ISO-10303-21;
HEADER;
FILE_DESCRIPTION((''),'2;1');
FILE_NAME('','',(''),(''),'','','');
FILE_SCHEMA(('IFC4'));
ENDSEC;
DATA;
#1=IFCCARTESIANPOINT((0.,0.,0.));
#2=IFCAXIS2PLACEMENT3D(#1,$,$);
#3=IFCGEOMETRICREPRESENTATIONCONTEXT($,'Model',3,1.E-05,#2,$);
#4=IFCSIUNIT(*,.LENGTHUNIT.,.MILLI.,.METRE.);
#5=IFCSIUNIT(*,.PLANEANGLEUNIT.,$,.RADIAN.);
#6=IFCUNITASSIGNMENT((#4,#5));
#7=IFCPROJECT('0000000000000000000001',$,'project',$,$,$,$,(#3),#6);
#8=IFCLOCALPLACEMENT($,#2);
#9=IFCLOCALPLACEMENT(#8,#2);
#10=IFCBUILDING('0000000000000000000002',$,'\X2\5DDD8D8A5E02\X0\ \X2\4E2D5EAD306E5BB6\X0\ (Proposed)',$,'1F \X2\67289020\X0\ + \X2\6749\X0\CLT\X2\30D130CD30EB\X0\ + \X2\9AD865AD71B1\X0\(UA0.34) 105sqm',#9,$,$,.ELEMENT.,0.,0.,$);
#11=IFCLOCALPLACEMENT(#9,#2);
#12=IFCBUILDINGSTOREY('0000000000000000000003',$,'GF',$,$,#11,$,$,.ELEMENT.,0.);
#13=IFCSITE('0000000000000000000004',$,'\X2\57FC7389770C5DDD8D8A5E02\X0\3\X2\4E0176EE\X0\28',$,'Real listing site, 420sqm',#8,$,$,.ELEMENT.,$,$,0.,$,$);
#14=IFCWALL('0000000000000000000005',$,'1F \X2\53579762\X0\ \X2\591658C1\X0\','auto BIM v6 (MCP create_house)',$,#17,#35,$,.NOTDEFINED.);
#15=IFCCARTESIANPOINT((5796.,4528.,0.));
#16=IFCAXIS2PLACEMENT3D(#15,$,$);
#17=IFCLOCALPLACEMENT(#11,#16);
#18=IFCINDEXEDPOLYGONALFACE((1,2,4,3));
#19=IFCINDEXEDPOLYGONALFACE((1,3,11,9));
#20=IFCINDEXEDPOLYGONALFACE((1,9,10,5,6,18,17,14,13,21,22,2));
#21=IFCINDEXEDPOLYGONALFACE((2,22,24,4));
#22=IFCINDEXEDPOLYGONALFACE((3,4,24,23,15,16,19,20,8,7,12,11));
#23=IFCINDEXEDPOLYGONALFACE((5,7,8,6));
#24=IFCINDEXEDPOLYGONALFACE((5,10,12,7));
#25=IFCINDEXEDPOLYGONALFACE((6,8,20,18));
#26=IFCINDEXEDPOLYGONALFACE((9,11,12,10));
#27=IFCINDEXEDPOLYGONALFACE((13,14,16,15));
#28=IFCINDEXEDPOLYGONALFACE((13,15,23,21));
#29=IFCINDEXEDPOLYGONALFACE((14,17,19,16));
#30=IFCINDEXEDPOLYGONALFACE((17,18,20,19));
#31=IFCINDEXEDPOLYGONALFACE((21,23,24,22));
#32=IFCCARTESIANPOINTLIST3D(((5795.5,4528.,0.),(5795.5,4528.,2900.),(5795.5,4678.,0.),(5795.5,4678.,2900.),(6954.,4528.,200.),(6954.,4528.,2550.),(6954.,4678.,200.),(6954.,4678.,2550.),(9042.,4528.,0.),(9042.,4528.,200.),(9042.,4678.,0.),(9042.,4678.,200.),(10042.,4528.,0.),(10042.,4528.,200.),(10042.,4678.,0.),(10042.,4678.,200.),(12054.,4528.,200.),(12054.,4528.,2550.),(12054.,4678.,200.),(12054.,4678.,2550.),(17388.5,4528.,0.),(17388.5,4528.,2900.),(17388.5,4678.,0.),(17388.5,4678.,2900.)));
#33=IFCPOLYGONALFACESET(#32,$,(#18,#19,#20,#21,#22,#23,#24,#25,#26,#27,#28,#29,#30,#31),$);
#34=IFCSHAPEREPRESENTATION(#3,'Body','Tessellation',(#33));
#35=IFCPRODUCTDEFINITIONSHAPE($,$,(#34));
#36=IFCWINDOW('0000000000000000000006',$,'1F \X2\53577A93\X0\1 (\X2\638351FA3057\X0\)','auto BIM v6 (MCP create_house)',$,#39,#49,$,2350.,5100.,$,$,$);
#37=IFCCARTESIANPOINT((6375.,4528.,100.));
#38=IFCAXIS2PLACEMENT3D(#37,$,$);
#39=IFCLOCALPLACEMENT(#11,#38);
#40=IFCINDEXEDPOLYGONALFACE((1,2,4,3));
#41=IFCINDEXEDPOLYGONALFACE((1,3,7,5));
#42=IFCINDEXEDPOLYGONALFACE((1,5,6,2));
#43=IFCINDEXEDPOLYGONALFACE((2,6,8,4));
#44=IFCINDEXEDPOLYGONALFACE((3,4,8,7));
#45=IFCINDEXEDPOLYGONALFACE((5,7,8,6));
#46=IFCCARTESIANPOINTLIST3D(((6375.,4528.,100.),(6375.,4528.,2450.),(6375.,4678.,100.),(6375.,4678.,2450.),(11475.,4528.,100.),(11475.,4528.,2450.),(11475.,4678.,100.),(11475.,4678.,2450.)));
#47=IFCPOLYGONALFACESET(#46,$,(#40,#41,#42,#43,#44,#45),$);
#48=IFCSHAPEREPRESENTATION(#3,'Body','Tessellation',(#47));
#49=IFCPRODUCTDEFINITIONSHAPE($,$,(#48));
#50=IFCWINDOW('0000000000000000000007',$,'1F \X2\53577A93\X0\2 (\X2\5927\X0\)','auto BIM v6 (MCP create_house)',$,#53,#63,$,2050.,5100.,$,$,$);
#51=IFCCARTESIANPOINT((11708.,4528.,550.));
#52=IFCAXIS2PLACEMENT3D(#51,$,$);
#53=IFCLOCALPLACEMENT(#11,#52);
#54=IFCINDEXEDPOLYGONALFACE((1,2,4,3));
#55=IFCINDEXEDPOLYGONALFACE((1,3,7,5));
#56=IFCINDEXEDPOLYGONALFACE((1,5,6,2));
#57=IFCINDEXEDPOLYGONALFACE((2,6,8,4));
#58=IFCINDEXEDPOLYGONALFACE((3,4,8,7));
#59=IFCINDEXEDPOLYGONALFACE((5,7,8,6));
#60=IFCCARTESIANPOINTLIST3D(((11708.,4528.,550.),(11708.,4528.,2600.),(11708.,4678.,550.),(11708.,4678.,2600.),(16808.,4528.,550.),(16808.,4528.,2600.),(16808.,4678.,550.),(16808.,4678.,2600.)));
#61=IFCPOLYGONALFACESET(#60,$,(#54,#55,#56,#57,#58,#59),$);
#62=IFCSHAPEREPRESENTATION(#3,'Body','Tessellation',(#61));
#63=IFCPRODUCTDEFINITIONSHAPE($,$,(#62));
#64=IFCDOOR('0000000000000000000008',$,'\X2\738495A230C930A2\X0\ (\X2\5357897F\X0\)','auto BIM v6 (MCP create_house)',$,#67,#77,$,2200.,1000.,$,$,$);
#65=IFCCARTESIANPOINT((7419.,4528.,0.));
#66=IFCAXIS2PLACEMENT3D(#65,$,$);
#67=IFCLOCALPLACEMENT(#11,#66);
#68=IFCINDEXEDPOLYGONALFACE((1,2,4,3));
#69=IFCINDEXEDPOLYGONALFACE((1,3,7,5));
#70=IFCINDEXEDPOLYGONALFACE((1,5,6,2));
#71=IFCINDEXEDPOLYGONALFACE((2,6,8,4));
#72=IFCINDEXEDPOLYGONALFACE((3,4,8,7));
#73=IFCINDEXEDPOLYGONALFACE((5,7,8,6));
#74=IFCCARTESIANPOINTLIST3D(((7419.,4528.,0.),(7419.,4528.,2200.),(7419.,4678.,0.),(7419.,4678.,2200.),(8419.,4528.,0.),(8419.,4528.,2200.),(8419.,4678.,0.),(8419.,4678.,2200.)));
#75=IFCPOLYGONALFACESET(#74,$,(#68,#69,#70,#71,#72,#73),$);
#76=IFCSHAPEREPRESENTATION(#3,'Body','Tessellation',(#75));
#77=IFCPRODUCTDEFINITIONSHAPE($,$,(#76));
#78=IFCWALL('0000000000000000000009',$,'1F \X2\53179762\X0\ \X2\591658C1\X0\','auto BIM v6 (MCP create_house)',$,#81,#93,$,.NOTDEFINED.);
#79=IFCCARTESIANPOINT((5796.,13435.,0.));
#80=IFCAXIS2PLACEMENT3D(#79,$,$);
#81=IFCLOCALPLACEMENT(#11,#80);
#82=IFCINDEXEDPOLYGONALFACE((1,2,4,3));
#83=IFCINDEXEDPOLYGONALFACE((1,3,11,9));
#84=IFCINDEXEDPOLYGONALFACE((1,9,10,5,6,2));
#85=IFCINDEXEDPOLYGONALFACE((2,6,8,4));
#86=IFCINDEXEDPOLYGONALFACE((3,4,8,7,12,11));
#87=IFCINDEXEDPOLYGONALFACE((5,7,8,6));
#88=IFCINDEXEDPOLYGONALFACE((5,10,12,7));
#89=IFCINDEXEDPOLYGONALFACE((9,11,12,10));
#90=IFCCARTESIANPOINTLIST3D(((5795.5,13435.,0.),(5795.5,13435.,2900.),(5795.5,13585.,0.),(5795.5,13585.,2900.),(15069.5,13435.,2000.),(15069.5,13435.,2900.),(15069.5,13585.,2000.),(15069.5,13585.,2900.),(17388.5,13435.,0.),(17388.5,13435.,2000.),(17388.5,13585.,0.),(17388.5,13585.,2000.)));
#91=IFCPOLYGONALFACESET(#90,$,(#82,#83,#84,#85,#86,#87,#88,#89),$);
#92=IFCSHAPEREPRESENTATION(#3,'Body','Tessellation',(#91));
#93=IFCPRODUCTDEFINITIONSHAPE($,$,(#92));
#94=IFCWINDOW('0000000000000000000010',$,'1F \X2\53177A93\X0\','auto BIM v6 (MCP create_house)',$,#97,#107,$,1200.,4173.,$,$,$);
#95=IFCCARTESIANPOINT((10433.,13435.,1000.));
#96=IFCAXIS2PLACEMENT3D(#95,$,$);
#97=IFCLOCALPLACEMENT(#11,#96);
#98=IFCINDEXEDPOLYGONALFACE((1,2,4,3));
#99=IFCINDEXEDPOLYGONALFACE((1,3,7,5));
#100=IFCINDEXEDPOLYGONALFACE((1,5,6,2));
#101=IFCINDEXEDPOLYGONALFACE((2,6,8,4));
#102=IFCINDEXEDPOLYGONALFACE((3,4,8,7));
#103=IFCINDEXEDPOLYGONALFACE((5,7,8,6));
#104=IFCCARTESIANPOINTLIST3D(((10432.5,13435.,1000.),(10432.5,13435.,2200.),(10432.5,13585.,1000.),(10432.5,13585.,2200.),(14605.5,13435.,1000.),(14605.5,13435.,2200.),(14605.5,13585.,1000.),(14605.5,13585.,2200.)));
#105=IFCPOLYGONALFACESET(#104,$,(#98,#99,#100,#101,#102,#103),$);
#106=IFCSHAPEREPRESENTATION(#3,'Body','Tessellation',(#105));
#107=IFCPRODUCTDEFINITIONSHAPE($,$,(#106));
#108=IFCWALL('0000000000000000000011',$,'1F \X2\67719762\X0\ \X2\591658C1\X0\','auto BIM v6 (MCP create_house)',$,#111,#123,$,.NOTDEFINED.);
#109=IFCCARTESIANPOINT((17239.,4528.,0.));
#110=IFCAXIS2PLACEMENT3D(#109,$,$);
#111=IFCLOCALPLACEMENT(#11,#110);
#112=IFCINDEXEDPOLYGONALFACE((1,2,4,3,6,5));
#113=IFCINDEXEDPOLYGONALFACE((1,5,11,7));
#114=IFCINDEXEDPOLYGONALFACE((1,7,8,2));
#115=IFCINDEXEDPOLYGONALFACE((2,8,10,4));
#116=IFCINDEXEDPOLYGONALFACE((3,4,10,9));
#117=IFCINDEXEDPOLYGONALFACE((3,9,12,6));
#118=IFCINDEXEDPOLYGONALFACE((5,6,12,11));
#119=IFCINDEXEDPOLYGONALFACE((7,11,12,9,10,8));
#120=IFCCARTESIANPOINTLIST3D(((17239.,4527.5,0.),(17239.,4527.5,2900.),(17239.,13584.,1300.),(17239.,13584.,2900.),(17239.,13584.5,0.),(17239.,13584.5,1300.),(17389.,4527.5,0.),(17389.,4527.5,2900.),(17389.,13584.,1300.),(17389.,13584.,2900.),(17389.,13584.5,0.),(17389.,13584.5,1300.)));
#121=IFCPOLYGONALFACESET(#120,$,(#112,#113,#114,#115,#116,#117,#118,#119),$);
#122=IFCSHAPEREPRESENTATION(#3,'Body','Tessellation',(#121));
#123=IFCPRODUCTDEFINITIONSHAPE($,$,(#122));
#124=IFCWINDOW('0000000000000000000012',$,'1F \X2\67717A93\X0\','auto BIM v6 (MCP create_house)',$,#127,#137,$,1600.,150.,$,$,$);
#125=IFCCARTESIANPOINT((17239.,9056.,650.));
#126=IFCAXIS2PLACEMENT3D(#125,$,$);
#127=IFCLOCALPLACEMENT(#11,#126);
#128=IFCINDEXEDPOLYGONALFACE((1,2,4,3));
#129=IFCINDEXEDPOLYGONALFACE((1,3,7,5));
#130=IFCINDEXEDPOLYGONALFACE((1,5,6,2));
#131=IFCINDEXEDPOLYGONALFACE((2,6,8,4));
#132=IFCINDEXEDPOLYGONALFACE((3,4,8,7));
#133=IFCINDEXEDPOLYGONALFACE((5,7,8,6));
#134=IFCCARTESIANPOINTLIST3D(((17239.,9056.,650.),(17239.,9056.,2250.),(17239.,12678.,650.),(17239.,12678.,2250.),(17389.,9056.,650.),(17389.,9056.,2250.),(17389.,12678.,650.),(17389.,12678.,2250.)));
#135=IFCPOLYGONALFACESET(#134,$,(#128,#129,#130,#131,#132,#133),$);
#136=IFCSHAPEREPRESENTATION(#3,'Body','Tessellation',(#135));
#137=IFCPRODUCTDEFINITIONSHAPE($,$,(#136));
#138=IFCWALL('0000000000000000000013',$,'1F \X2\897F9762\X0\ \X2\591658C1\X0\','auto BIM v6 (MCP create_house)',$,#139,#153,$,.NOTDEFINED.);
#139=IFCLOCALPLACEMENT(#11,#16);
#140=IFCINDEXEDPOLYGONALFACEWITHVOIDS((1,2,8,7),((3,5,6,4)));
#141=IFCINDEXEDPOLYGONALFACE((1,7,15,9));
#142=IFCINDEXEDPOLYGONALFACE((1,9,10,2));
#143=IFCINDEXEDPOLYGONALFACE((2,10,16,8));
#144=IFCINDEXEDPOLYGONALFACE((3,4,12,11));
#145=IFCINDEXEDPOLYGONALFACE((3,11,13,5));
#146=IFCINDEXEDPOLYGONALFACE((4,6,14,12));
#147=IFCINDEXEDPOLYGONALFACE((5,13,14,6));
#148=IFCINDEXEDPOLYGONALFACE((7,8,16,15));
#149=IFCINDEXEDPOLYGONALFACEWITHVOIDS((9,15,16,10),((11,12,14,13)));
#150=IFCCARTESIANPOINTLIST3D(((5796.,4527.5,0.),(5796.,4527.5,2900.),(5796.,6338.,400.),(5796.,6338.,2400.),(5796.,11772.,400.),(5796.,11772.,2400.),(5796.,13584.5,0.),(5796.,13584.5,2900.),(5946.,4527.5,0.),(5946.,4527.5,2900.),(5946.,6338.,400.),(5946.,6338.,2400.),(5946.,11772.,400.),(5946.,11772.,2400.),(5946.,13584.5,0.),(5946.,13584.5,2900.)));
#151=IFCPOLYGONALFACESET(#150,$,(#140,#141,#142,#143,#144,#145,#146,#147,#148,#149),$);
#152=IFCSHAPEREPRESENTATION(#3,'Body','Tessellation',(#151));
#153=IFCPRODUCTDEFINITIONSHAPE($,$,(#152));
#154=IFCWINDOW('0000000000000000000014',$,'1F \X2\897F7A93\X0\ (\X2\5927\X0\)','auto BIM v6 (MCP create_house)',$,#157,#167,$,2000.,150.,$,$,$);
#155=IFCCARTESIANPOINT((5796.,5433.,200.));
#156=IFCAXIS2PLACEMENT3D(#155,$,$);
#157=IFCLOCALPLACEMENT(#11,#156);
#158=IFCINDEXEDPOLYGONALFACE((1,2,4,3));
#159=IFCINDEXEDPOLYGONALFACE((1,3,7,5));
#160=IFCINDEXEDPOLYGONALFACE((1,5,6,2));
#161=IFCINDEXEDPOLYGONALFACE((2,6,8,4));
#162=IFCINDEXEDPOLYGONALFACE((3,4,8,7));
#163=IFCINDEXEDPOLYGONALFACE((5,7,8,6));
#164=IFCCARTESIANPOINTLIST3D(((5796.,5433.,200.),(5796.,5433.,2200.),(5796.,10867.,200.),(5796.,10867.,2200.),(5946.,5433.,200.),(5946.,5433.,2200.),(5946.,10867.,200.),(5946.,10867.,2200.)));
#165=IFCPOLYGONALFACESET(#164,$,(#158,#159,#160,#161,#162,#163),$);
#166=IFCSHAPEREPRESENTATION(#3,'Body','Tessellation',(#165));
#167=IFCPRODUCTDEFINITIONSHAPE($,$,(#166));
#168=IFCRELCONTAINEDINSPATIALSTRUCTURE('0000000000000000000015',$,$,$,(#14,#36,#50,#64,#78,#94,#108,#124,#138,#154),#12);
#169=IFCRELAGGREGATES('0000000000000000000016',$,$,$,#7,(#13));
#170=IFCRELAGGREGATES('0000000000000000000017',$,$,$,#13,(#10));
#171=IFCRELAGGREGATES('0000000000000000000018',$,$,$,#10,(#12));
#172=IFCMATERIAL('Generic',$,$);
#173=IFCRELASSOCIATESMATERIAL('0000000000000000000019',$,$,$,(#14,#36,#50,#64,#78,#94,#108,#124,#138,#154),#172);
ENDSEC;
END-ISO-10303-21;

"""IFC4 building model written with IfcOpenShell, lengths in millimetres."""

from ifc_helpers import new_model, si_unit, frame, frame_2d, origin, place, context, project, spatial, rectangle, extrude, material, element, fill, save


model = new_model("IFC4")

# Units and contexts
model_context = context("Model", 3, precision=1e-05, world=origin())
ifc_project = project(units=[si_unit("LENGTHUNIT", "METRE", prefix="MILLI"), si_unit("PLANEANGLEUNIT", "RADIAN")], contexts=[model_context])

# Site, building, storey
site_placement = place(None, origin())
site = spatial("IfcSite", under=ifc_project, at=site_placement, Name="埼玉県川越市3丁目28", ObjectType="Real listing site, 420sqm", CompositionType="ELEMENT", RefElevation=0.0)
building_placement = place(site_placement, origin())
building = spatial("IfcBuilding", under=site, at=building_placement, Name="川越市 中庭の家 (Proposed)", ObjectType="1F 木造 + 杉CLTパネル + 高断熱(UA0.34) 105sqm", CompositionType="ELEMENT", ElevationOfRefHeight=0.0, ElevationOfTerrain=0.0)
storey_placement = place(building_placement, origin())
storey = spatial("IfcBuildingStorey", under=building, at=storey_placement, Name="GF", CompositionType="ELEMENT", Elevation=0.0)

# Shared definitions
ifc_material = material(Name="Generic")

# Wall, openings, windows, door
wall_1_placement = place(storey_placement, frame((5796.0, 4528.0, 0.0)))
wall_1 = element("IfcWall", 1, at=wall_1_placement, inside=storey, material=ifc_material, Name="1F 南面 外壁", Description="auto BIM v6 (MCP create_house)", PredefinedType="NOTDEFINED", context=model_context, shape_type="SweptSolid", body=[
    extrude(rectangle(XDim=11593.0, YDim=150.0, at=frame_2d((5796.0, 75.0))), frame((5796.0, 4528.0, 0.0)), (0.0, 0.0, 1.0), 2900.0),
])
opening_1_placement = place(storey_placement, frame((6375.0, 4528.0, 100.0)))
opening_1 = element("IfcOpeningElement", 2, at=opening_1_placement, cuts=wall_1, PredefinedType="NOTDEFINED", context=model_context, shape_type="SweptSolid", body=[
    extrude(rectangle(XDim=5100.0, YDim=150.0, at=frame_2d((2550.0, 75.0))), frame((6375.0, 4528.0, 100.0)), (0.0, 0.0, 1.0), 2350.0),
])
opening_2_placement = place(storey_placement, frame((11708.0, 4528.0, 550.0)))
opening_2 = element("IfcOpeningElement", 3, at=opening_2_placement, cuts=wall_1, PredefinedType="NOTDEFINED", context=model_context, shape_type="SweptSolid", body=[
    extrude(rectangle(XDim=5100.0, YDim=150.0, at=frame_2d((2550.0, 75.0))), frame((11708.0, 4528.0, 550.0)), (0.0, 0.0, 1.0), 2050.0),
])
opening_3_placement = place(storey_placement, frame((7419.0, 4528.0, 0.0)))
opening_3 = element("IfcOpeningElement", 4, at=opening_3_placement, cuts=wall_1, PredefinedType="NOTDEFINED", context=model_context, shape_type="SweptSolid", body=[
    extrude(rectangle(XDim=1000.0, YDim=150.0, at=frame_2d((500.0, 75.0))), frame((7419.0, 4528.0, 0.0)), (0.0, 0.0, 1.0), 2200.0),
])
window_1_placement = place(storey_placement, frame((6375.0, 4528.0, 100.0)))
window_1 = element("IfcWindow", 5, at=window_1_placement, inside=storey, material=ifc_material, Name="1F 南窓1 (掃出し)", Description="auto BIM v6 (MCP create_house)", OverallHeight=2350.0, OverallWidth=5100.0, context=model_context, shape_type="SweptSolid", body=[
    extrude(rectangle(XDim=5100.0, YDim=150.0, at=frame_2d((2550.0, 75.0))), frame((6375.0, 4528.0, 100.0)), (0.0, 0.0, 1.0), 2350.0),
])
fill(opening_1, window_1)
window_2_placement = place(storey_placement, frame((11708.0, 4528.0, 550.0)))
window_2 = element("IfcWindow", 6, at=window_2_placement, inside=storey, material=ifc_material, Name="1F 南窓2 (大)", Description="auto BIM v6 (MCP create_house)", OverallHeight=2050.0, OverallWidth=5100.0, context=model_context, shape_type="SweptSolid", body=[
    extrude(rectangle(XDim=5100.0, YDim=150.0, at=frame_2d((2550.0, 75.0))), frame((11708.0, 4528.0, 550.0)), (0.0, 0.0, 1.0), 2050.0),
])
fill(opening_2, window_2)
door_placement = place(storey_placement, frame((7419.0, 4528.0, 0.0)))
door = element("IfcDoor", 7, at=door_placement, inside=storey, material=ifc_material, Name="玄関ドア (南西)", Description="auto BIM v6 (MCP create_house)", OverallHeight=2200.0, OverallWidth=1000.0, context=model_context, shape_type="SweptSolid", body=[
    extrude(rectangle(XDim=1000.0, YDim=150.0, at=frame_2d((500.0, 75.0))), frame((7419.0, 4528.0, 0.0)), (0.0, 0.0, 1.0), 2200.0),
])
fill(opening_3, door)

# Walls, openings, windows
wall_2_placement = place(storey_placement, frame((5796.0, 13435.0, 0.0)))
wall_2 = element("IfcWall", 8, at=wall_2_placement, inside=storey, material=ifc_material, Name="1F 北面 外壁", Description="auto BIM v6 (MCP create_house)", PredefinedType="NOTDEFINED", context=model_context, shape_type="SweptSolid", body=[
    extrude(rectangle(XDim=11593.0, YDim=150.0, at=frame_2d((5796.0, 75.0))), frame((5796.0, 13435.0, 0.0)), (0.0, 0.0, 1.0), 2900.0),
])
opening_4_placement = place(storey_placement, frame((10433.0, 13435.0, 1000.0)))
opening_4 = element("IfcOpeningElement", 9, at=opening_4_placement, cuts=wall_2, PredefinedType="NOTDEFINED", context=model_context, shape_type="SweptSolid", body=[
    extrude(rectangle(XDim=4173.0, YDim=150.0, at=frame_2d((2086.0, 75.0))), frame((10433.0, 13435.0, 1000.0)), (0.0, 0.0, 1.0), 1200.0),
])
window_3_placement = place(storey_placement, frame((10433.0, 13435.0, 1000.0)))
window_3 = element("IfcWindow", 10, at=window_3_placement, inside=storey, material=ifc_material, Name="1F 北窓", Description="auto BIM v6 (MCP create_house)", OverallHeight=1200.0, OverallWidth=4173.0, context=model_context, shape_type="SweptSolid", body=[
    extrude(rectangle(XDim=4173.0, YDim=150.0, at=frame_2d((2086.0, 75.0))), frame((10433.0, 13435.0, 1000.0)), (0.0, 0.0, 1.0), 1200.0),
])
fill(opening_4, window_3)
wall_3_placement = place(storey_placement, frame((17239.0, 4528.0, 0.0)))
wall_3 = element("IfcWall", 11, at=wall_3_placement, inside=storey, material=ifc_material, Name="1F 東面 外壁", Description="auto BIM v6 (MCP create_house)", PredefinedType="NOTDEFINED", context=model_context, shape_type="SweptSolid", body=[
    extrude(rectangle(XDim=150.0, YDim=9057.0, at=frame_2d((75.0, 4528.0))), frame((17239.0, 4528.0, 0.0)), (0.0, 0.0, 1.0), 2900.0),
])
opening_5_placement = place(storey_placement, frame((17239.0, 9056.0, 650.0)))
opening_5 = element("IfcOpeningElement", 12, at=opening_5_placement, cuts=wall_3, PredefinedType="NOTDEFINED", context=model_context, shape_type="SweptSolid", body=[
    extrude(rectangle(XDim=150.0, YDim=3622.0, at=frame_2d((75.0, 1811.0))), frame((17239.0, 9056.0, 650.0)), (0.0, 0.0, 1.0), 1600.0),
])
window_4_placement = place(storey_placement, frame((17239.0, 9056.0, 650.0)))
window_4 = element("IfcWindow", 13, at=window_4_placement, inside=storey, material=ifc_material, Name="1F 東窓", Description="auto BIM v6 (MCP create_house)", OverallHeight=1600.0, OverallWidth=150.0, context=model_context, shape_type="SweptSolid", body=[
    extrude(rectangle(XDim=150.0, YDim=3622.0, at=frame_2d((75.0, 1811.0))), frame((17239.0, 9056.0, 650.0)), (0.0, 0.0, 1.0), 1600.0),
])
fill(opening_5, window_4)
wall_4_placement = place(storey_placement, frame((5796.0, 4528.0, 0.0)))
wall_4 = element("IfcWall", 14, at=wall_4_placement, inside=storey, material=ifc_material, Name="1F 西面 外壁", Description="auto BIM v6 (MCP create_house)", PredefinedType="NOTDEFINED", context=model_context, shape_type="SweptSolid", body=[
    extrude(rectangle(XDim=150.0, YDim=9057.0, at=frame_2d((75.0, 4528.0))), frame((5796.0, 4528.0, 0.0)), (0.0, 0.0, 1.0), 2900.0),
])
opening_6_placement = place(storey_placement, frame((5796.0, 5433.0, 200.0)))
opening_6 = element("IfcOpeningElement", 15, at=opening_6_placement, cuts=wall_4, PredefinedType="NOTDEFINED", context=model_context, shape_type="SweptSolid", body=[
    extrude(rectangle(XDim=150.0, YDim=5434.0, at=frame_2d((75.0, 2717.0))), frame((5796.0, 5433.0, 200.0)), (0.0, 0.0, 1.0), 2000.0),
])
window_5_placement = place(storey_placement, frame((5796.0, 5433.0, 200.0)))
window_5 = element("IfcWindow", 16, at=window_5_placement, inside=storey, material=ifc_material, Name="1F 西窓 (大)", Description="auto BIM v6 (MCP create_house)", OverallHeight=2000.0, OverallWidth=150.0, context=model_context, shape_type="SweptSolid", body=[
    extrude(rectangle(XDim=150.0, YDim=5434.0, at=frame_2d((75.0, 2717.0))), frame((5796.0, 5433.0, 200.0)), (0.0, 0.0, 1.0), 2000.0),
])
fill(opening_6, window_5)

save(model, "model.ifc")
